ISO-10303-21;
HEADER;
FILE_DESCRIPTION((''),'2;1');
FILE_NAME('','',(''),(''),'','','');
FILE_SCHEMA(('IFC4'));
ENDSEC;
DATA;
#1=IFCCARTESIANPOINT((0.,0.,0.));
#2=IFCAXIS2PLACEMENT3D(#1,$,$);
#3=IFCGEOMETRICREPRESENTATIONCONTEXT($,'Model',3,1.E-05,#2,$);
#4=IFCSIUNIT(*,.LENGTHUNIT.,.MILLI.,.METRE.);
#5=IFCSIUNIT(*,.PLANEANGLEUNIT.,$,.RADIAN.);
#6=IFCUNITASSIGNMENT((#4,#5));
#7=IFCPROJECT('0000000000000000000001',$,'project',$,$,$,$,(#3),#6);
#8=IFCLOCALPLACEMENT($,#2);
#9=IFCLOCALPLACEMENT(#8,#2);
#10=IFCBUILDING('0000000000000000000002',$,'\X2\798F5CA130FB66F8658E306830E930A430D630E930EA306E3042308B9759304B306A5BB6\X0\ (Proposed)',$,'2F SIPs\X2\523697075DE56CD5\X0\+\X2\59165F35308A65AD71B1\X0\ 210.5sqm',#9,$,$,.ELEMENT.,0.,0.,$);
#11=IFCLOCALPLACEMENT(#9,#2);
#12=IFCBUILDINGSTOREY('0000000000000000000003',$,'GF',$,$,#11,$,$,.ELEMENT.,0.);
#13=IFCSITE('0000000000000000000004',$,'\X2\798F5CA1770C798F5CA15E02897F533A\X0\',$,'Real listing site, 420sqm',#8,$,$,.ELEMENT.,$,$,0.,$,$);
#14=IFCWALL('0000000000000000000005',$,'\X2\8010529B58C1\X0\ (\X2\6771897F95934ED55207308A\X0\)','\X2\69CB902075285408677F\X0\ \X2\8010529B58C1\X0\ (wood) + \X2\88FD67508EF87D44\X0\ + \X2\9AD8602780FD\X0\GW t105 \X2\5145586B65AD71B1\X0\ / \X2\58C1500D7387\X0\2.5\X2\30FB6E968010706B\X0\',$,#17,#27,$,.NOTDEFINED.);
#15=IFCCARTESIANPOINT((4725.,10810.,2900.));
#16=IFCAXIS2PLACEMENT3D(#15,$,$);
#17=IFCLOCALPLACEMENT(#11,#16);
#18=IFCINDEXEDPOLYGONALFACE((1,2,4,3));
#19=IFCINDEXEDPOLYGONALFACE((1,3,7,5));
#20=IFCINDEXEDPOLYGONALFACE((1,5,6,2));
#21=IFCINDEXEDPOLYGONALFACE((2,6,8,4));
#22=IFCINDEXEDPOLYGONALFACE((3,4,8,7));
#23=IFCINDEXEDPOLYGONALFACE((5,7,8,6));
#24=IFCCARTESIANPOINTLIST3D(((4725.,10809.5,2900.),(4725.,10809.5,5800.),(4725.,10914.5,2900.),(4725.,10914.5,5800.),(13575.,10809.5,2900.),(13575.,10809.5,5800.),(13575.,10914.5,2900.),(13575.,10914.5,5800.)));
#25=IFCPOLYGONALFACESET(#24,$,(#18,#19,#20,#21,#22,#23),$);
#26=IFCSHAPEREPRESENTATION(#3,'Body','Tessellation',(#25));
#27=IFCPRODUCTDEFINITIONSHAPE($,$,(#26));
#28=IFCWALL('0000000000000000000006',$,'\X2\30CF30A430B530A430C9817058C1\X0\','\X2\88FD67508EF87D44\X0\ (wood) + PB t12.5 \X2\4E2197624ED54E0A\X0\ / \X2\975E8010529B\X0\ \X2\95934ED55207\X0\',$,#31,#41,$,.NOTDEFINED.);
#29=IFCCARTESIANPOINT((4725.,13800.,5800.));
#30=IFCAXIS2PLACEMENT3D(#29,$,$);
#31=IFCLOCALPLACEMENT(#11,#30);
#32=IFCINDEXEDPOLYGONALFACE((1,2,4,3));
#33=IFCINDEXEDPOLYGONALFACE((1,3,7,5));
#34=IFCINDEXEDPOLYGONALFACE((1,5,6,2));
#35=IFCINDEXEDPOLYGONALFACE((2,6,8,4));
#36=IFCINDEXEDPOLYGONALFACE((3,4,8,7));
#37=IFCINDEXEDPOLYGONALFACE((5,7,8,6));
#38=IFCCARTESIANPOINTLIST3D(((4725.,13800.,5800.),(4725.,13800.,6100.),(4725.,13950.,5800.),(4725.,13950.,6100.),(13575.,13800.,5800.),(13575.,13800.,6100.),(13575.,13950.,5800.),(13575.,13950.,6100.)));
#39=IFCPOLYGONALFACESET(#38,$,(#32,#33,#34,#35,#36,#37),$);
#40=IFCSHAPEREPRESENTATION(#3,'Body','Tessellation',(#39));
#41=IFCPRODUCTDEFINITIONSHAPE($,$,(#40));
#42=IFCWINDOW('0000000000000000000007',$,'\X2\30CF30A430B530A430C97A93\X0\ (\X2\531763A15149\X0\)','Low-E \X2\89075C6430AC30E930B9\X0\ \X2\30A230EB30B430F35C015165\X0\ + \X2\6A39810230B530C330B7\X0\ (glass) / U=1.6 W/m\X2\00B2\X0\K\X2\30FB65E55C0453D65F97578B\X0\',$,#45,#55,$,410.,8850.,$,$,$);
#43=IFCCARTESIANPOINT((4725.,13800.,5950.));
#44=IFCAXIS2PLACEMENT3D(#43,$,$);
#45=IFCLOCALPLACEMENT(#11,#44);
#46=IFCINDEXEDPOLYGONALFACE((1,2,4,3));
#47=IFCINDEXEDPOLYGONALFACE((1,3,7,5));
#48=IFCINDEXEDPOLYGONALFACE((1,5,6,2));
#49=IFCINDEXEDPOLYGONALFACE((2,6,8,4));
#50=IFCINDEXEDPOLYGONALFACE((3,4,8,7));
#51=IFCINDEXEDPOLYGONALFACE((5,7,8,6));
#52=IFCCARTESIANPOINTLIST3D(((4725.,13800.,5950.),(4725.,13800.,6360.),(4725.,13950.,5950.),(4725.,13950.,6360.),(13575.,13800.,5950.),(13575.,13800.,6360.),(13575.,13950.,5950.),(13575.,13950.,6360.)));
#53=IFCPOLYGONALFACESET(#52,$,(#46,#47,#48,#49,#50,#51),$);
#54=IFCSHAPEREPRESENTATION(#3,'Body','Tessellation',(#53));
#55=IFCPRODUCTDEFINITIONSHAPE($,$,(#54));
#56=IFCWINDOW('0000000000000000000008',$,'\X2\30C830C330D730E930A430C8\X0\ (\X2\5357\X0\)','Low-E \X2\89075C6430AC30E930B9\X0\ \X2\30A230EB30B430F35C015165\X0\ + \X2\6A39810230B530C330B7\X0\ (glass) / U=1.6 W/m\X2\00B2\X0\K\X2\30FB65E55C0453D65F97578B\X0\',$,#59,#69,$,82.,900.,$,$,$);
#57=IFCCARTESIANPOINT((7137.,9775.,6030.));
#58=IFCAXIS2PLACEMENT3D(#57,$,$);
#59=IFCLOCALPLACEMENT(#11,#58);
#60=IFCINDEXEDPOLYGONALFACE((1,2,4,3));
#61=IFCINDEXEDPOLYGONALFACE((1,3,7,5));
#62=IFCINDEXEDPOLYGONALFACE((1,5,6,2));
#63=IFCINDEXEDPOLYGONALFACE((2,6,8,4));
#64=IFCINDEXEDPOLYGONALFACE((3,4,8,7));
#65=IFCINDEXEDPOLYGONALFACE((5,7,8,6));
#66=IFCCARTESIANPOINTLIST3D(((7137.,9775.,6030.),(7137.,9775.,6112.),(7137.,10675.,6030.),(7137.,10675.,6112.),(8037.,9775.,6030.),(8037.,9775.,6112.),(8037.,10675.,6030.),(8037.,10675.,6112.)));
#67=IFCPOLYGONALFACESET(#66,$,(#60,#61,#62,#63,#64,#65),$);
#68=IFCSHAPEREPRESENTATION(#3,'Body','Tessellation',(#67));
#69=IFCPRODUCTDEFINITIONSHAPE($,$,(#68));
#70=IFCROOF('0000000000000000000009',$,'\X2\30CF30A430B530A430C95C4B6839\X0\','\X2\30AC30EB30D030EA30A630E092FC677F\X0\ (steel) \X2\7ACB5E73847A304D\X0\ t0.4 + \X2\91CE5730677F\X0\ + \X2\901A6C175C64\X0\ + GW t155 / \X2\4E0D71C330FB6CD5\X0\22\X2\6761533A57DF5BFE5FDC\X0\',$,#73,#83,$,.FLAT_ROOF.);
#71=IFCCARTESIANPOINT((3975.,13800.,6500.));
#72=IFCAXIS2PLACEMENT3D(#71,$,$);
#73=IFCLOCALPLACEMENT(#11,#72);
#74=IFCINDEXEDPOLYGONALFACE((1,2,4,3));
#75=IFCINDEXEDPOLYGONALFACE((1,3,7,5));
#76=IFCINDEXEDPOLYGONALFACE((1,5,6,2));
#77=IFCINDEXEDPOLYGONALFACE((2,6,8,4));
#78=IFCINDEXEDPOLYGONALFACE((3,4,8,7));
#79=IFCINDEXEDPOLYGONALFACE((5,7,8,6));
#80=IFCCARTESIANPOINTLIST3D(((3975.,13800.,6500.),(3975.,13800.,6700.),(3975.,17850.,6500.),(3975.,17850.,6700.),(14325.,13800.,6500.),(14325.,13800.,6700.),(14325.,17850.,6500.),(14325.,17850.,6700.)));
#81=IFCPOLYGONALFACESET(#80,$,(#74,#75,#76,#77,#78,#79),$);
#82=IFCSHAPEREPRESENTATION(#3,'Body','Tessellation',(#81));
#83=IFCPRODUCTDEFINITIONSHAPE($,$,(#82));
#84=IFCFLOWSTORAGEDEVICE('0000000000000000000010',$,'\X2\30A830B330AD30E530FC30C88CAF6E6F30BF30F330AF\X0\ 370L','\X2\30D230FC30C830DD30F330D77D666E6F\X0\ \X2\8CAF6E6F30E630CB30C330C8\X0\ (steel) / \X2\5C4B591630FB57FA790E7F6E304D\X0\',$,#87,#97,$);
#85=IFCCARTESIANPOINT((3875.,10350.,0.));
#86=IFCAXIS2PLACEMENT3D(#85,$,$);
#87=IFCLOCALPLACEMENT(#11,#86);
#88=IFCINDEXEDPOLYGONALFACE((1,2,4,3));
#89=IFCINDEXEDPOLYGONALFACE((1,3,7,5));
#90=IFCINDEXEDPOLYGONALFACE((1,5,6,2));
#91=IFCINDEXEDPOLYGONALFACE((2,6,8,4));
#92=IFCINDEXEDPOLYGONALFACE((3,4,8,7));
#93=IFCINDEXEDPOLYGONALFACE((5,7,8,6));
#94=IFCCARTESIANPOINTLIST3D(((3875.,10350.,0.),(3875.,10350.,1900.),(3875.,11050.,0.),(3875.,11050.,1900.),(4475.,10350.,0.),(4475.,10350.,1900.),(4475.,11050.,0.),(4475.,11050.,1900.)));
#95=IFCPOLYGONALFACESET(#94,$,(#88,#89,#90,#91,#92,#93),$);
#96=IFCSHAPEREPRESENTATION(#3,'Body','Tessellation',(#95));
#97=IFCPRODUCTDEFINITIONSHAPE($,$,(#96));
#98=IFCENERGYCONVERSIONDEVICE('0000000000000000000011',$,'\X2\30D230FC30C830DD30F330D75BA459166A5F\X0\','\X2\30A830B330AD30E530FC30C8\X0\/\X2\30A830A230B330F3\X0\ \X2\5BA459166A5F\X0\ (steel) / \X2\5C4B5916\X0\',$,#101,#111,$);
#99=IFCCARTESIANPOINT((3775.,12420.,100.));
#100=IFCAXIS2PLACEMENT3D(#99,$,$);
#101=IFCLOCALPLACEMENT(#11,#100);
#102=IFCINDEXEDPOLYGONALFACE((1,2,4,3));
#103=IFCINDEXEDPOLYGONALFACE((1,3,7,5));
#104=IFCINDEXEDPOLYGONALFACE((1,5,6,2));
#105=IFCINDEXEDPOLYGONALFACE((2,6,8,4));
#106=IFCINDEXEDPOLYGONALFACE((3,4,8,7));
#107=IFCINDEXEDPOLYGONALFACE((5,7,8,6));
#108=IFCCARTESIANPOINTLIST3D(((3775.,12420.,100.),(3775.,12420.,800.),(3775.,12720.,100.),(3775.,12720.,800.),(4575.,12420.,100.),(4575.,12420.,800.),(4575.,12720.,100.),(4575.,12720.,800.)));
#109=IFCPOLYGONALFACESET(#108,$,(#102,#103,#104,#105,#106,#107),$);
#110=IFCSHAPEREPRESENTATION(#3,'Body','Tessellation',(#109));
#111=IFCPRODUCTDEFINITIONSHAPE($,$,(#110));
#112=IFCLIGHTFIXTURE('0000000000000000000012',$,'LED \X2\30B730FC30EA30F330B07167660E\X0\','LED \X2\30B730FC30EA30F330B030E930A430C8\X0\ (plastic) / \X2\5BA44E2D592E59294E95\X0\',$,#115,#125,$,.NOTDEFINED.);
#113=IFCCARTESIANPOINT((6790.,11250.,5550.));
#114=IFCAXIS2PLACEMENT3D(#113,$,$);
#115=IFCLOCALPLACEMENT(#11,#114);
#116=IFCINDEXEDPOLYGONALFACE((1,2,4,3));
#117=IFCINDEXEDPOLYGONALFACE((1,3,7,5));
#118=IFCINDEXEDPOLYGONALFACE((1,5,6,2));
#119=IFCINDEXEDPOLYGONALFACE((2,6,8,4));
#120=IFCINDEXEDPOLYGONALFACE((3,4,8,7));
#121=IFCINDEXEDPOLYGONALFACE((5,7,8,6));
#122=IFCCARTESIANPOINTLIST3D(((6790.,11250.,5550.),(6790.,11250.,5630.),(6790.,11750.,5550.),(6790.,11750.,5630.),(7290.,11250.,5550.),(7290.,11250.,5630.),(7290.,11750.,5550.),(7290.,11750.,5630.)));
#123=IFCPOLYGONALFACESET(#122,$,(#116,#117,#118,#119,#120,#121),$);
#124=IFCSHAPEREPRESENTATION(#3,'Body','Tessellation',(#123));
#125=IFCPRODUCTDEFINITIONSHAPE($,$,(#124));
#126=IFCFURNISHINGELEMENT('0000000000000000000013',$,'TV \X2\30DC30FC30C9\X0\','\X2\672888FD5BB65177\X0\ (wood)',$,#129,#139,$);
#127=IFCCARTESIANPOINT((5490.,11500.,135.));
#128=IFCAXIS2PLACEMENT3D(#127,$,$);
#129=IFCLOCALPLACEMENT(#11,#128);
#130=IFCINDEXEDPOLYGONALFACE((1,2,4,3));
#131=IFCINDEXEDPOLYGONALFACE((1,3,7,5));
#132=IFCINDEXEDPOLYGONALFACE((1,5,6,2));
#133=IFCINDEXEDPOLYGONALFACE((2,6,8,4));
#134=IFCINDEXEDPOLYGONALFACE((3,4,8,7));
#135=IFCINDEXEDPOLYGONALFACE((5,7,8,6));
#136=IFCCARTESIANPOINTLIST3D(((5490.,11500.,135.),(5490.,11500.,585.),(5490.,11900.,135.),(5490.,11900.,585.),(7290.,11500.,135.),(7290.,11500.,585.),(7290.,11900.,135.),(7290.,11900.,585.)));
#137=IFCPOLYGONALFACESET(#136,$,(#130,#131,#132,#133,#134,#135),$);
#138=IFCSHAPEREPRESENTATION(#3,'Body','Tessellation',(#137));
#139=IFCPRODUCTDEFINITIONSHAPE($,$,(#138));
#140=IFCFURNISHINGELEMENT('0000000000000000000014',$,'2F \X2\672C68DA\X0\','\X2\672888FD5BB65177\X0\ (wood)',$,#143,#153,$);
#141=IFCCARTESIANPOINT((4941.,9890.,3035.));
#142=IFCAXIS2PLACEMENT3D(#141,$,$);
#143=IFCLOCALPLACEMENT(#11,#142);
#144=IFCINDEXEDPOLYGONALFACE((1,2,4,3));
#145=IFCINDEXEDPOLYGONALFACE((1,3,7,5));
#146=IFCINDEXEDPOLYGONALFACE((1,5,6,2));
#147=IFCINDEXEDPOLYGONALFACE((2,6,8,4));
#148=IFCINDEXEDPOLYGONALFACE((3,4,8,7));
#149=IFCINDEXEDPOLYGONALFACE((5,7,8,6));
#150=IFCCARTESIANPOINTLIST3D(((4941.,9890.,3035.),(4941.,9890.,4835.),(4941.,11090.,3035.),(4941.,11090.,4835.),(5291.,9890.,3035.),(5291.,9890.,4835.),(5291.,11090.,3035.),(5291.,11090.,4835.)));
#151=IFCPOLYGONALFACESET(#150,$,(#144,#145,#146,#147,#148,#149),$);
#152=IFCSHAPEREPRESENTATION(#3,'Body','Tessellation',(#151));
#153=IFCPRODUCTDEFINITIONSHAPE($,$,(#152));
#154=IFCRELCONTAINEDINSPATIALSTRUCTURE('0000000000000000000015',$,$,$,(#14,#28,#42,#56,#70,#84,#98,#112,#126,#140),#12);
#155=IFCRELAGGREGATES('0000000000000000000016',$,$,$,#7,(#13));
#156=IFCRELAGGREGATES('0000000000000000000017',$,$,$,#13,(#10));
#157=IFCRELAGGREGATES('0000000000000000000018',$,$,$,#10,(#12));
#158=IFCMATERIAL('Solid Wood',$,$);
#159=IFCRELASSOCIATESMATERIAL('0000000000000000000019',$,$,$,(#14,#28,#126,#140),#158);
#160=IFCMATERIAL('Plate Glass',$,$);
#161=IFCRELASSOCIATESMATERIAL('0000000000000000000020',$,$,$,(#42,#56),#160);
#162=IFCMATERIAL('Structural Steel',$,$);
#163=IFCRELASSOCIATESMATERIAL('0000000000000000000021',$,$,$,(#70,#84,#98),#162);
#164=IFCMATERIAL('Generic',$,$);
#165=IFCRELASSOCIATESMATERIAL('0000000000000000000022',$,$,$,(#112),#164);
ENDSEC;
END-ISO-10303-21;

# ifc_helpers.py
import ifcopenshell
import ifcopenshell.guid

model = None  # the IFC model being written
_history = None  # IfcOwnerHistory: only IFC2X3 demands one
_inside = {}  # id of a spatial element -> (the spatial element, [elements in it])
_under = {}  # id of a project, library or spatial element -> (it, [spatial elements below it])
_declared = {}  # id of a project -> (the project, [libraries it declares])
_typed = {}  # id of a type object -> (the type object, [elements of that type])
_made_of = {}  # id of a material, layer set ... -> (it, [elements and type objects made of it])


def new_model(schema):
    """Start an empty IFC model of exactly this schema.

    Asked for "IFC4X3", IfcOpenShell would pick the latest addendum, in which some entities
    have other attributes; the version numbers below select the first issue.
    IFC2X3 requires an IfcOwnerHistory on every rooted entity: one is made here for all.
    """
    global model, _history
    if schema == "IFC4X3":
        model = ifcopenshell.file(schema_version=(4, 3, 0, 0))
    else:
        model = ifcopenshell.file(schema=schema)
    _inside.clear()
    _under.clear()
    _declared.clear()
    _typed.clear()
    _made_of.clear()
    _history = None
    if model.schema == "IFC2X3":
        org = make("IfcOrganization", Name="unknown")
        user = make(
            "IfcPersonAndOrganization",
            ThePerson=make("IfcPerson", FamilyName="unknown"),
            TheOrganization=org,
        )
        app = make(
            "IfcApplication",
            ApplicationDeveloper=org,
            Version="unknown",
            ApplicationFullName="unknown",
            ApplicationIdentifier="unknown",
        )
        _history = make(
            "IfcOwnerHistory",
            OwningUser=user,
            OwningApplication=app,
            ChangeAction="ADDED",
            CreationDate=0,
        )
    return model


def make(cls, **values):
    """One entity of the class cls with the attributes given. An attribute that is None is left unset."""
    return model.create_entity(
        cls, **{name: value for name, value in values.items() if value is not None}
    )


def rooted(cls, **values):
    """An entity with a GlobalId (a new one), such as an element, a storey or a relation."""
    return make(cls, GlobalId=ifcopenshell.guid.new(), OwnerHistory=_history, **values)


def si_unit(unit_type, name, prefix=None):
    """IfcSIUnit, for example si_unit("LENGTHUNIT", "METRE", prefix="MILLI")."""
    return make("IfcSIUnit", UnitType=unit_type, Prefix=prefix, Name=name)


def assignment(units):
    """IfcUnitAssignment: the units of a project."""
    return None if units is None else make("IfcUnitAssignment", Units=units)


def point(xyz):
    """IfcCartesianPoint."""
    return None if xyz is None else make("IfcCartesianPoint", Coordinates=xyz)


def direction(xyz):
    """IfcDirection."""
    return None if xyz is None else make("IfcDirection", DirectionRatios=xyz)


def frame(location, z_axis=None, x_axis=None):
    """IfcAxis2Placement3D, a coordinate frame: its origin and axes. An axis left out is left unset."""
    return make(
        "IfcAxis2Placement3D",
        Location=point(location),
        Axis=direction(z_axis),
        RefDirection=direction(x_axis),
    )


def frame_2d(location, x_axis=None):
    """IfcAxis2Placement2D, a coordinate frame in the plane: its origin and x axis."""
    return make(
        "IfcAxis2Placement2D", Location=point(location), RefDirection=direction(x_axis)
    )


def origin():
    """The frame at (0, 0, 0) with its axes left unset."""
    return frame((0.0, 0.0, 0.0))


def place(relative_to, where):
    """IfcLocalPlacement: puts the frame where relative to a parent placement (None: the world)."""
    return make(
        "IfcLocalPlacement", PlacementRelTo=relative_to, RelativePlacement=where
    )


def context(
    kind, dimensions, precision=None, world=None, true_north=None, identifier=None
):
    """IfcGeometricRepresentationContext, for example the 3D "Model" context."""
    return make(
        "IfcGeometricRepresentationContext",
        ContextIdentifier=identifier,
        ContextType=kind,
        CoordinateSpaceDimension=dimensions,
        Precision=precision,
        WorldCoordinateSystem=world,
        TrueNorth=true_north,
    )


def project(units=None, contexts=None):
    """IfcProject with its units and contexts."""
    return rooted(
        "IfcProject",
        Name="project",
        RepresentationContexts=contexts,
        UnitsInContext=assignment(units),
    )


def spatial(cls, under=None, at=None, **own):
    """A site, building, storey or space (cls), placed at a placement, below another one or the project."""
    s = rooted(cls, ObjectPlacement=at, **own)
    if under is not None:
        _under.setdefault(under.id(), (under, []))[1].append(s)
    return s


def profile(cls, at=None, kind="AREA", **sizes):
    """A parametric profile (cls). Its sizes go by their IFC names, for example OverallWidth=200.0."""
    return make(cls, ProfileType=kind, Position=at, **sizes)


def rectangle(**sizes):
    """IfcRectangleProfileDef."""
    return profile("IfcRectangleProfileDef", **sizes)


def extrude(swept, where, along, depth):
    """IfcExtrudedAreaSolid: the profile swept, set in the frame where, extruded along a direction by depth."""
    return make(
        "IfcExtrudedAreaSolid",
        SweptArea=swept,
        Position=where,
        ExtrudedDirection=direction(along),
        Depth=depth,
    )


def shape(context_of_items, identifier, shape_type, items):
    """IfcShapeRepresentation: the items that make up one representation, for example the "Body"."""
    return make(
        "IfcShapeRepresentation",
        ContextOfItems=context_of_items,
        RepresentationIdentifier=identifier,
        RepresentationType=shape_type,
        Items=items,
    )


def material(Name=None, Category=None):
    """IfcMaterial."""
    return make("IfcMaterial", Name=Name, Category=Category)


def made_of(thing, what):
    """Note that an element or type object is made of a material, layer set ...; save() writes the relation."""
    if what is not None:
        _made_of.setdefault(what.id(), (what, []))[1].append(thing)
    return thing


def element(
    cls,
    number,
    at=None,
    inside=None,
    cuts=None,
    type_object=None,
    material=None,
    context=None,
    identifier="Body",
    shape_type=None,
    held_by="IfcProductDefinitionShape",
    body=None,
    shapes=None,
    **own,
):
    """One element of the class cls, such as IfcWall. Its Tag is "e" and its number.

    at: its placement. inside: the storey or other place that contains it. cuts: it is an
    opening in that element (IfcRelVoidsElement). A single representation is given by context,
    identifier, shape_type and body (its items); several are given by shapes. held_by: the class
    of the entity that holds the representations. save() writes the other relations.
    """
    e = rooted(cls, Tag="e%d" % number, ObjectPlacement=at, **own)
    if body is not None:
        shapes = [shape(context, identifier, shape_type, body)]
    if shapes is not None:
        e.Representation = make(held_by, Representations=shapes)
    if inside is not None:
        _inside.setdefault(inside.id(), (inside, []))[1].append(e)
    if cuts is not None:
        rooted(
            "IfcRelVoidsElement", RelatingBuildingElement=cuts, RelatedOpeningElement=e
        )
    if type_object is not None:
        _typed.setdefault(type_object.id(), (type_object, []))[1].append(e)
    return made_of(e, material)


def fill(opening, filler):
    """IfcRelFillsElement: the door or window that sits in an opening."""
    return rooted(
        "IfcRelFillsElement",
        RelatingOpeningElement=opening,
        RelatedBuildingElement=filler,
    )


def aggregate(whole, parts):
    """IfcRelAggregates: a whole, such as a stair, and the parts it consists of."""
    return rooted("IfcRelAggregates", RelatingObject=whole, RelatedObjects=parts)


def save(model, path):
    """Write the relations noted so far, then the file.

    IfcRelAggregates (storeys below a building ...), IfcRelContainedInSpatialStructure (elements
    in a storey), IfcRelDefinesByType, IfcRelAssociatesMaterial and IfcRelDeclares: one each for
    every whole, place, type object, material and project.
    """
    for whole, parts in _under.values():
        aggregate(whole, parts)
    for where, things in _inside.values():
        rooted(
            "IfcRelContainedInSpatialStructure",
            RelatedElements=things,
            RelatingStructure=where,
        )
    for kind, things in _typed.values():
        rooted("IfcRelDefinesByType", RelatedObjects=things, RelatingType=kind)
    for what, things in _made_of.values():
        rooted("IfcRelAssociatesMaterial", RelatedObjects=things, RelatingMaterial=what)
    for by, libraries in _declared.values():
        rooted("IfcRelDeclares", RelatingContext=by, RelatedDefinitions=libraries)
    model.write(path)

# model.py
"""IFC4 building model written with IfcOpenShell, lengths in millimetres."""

from ifc_helpers import new_model, si_unit, frame, frame_2d, origin, place, context, project, spatial, rectangle, extrude, material, element, fill, save


model = new_model("IFC4")

# Units and contexts
model_context = context("Model", 3, precision=1e-05, world=origin())
ifc_project = project(units=[si_unit("LENGTHUNIT", "METRE", prefix="MILLI"), si_unit("PLANEANGLEUNIT", "RADIAN")], contexts=[model_context])

# Site, building, storey
site_placement = place(None, origin())
site = spatial("IfcSite", under=ifc_project, at=site_placement, Name="福岡県福岡市西区", ObjectType="Real listing site, 420sqm", CompositionType="ELEMENT", RefElevation=0.0)
building_placement = place(site_placement, origin())
building = spatial("IfcBuilding", under=site, at=building_placement, Name="福岡・書斎とライブラリのある静かな家 (Proposed)", ObjectType="2F SIPs制震工法+外張り断熱 210.5sqm", CompositionType="ELEMENT", ElevationOfRefHeight=0.0, ElevationOfTerrain=0.0)
storey_placement = place(building_placement, origin())
storey = spatial("IfcBuildingStorey", under=building, at=storey_placement, Name="GF", CompositionType="ELEMENT", Elevation=0.0)

# Shared definitions
ifc_material_1 = material(Name="Solid Wood")

# Wall
wall_1_placement = place(storey_placement, frame((4725.0, 10810.0, 2900.0)))
element("IfcWall", 1, at=wall_1_placement, inside=storey, material=ifc_material_1, Name="耐力壁 (東西間仕切り)", Description="構造用合板 耐力壁 (wood) + 製材軸組 + 高性能GW t105 充填断熱 / 壁倍率2.5・準耐火", PredefinedType="NOTDEFINED", context=model_context, shape_type="SweptSolid", body=[
    extrude(rectangle(XDim=8850.0, YDim=105.0, at=frame_2d((4425.0, 52.0))), frame((4725.0, 10810.0, 2900.0)), (0.0, 0.0, 1.0), 2900.0),
])

# Wall, opening, window
wall_2_placement = place(storey_placement, frame((4725.0, 13800.0, 5800.0)))
wall_2 = element("IfcWall", 2, at=wall_2_placement, inside=storey, material=ifc_material_1, Name="ハイサイド腰壁", Description="製材軸組 (wood) + PB t12.5 両面仕上 / 非耐力 間仕切", PredefinedType="NOTDEFINED", context=model_context, shape_type="SweptSolid", body=[
    extrude(rectangle(XDim=8850.0, YDim=150.0, at=frame_2d((4425.0, 75.0))), frame((4725.0, 13800.0, 5800.0)), (0.0, 0.0, 1.0), 700.0),
])
opening_1_placement = place(storey_placement, frame((4725.0, 13800.0, 5950.0)))
opening_1 = element("IfcOpeningElement", 3, at=opening_1_placement, cuts=wall_2, PredefinedType="NOTDEFINED", context=model_context, shape_type="SweptSolid", body=[
    extrude(rectangle(XDim=8850.0, YDim=150.0, at=frame_2d((4425.0, 75.0))), frame((4725.0, 13800.0, 5950.0)), (0.0, 0.0, 1.0), 410.0),
])
ifc_material_2 = material(Name="Plate Glass")
window_1_placement = place(storey_placement, frame((4725.0, 13800.0, 5950.0)))
window_1 = element("IfcWindow", 4, at=window_1_placement, inside=storey, material=ifc_material_2, Name="ハイサイド窓 (北採光)", Description="Low-E 複層ガラス アルゴン封入 + 樹脂サッシ (glass) / U=1.6 W/m²K・日射取得型", OverallHeight=410.0, OverallWidth=8850.0, context=model_context, shape_type="SweptSolid", body=[
    extrude(rectangle(XDim=8850.0, YDim=150.0, at=frame_2d((4425.0, 75.0))), frame((4725.0, 13800.0, 5950.0)), (0.0, 0.0, 1.0), 410.0),
])
fill(opening_1, window_1)

# Window
window_2_placement = place(storey_placement, frame((7137.0, 9775.0, 6030.0)))
element("IfcWindow", 5, at=window_2_placement, inside=storey, material=ifc_material_2, Name="トップライト (南)", Description="Low-E 複層ガラス アルゴン封入 + 樹脂サッシ (glass) / U=1.6 W/m²K・日射取得型", OverallHeight=82.0, OverallWidth=900.0, context=model_context, shape_type="SweptSolid", body=[
    extrude(rectangle(XDim=900.0, YDim=900.0, at=frame_2d((450.0, 450.0))), frame((7137.0, 9775.0, 6030.0)), (0.0, 0.0, 1.0), 82.0),
])

# Roof
ifc_material_3 = material(Name="Structural Steel")
roof_placement = place(storey_placement, frame((3975.0, 13800.0, 6500.0)))
element("IfcRoof", 6, at=roof_placement, inside=storey, material=ifc_material_3, Name="ハイサイド屋根", Description="ガルバリウム鋼板 (steel) 立平葺き t0.4 + 野地板 + 通気層 + GW t155 / 不燃・法22条区域対応", PredefinedType="FLAT_ROOF", context=model_context, shape_type="SweptSolid", body=[
    extrude(rectangle(XDim=10350.0, YDim=4050.0, at=frame_2d((5175.0, 2025.0))), frame((3975.0, 13800.0, 6500.0)), (0.0, 0.0, 1.0), 200.0),
])

# Flow storage device
flow_storage_device_placement = place(storey_placement, frame((3875.0, 10350.0, 0.0)))
element("IfcFlowStorageDevice", 7, at=flow_storage_device_placement, inside=storey, material=ifc_material_3, Name="エコキュート貯湯タンク 370L", Description="ヒートポンプ給湯 貯湯ユニット (steel) / 屋外・基礎置き", context=model_context, shape_type="SweptSolid", body=[
    extrude(rectangle(XDim=600.0, YDim=700.0, at=frame_2d((300.0, 350.0))), frame((3875.0, 10350.0, 0.0)), (0.0, 0.0, 1.0), 1900.0),
])

# Energy conversion device
energy_conversion_device_placement = place(storey_placement, frame((3775.0, 12420.0, 100.0)))
element("IfcEnergyConversionDevice", 8, at=energy_conversion_device_placement, inside=storey, material=ifc_material_3, Name="ヒートポンプ室外機", Description="エコキュート/エアコン 室外機 (steel) / 屋外", context=model_context, shape_type="SweptSolid", body=[
    extrude(rectangle(XDim=800.0, YDim=300.0, at=frame_2d((400.0, 150.0))), frame((3775.0, 12420.0, 100.0)), (0.0, 0.0, 1.0), 700.0),
])

# Light fixture
ifc_material_4 = material(Name="Generic")
light_fixture_placement = place(storey_placement, frame((6790.0, 11250.0, 5550.0)))
element("IfcLightFixture", 9, at=light_fixture_placement, inside=storey, material=ifc_material_4, Name="LED シーリング照明", Description="LED シーリングライト (plastic) / 室中央天井", PredefinedType="NOTDEFINED", context=model_context, shape_type="SweptSolid", body=[
    extrude(rectangle(XDim=500.0, YDim=500.0, at=frame_2d((250.0, 250.0))), frame((6790.0, 11250.0, 5550.0)), (0.0, 0.0, 1.0), 80.0),
])

# Furnishing elements
furnishing_1_placement = place(storey_placement, frame((5490.0, 11500.0, 135.0)))
element("IfcFurnishingElement", 10, at=furnishing_1_placement, inside=storey, material=ifc_material_1, Name="TV ボード", Description="木製家具 (wood)", context=model_context, shape_type="SweptSolid", body=[
    extrude(rectangle(XDim=1800.0, YDim=400.0, at=frame_2d((900.0, 200.0))), frame((5490.0, 11500.0, 135.0)), (0.0, 0.0, 1.0), 450.0),
])
furnishing_2_placement = place(storey_placement, frame((4941.0, 9890.0, 3035.0)))
element("IfcFurnishingElement", 11, at=furnishing_2_placement, inside=storey, material=ifc_material_1, Name="2F 本棚", Description="木製家具 (wood)", context=model_context, shape_type="SweptSolid", body=[
    extrude(rectangle(XDim=350.0, YDim=1200.0, at=frame_2d((175.0, 600.0))), frame((4941.0, 9890.0, 3035.0)), (0.0, 0.0, 1.0), 1800.0),
])

save(model, "model.ifc")
